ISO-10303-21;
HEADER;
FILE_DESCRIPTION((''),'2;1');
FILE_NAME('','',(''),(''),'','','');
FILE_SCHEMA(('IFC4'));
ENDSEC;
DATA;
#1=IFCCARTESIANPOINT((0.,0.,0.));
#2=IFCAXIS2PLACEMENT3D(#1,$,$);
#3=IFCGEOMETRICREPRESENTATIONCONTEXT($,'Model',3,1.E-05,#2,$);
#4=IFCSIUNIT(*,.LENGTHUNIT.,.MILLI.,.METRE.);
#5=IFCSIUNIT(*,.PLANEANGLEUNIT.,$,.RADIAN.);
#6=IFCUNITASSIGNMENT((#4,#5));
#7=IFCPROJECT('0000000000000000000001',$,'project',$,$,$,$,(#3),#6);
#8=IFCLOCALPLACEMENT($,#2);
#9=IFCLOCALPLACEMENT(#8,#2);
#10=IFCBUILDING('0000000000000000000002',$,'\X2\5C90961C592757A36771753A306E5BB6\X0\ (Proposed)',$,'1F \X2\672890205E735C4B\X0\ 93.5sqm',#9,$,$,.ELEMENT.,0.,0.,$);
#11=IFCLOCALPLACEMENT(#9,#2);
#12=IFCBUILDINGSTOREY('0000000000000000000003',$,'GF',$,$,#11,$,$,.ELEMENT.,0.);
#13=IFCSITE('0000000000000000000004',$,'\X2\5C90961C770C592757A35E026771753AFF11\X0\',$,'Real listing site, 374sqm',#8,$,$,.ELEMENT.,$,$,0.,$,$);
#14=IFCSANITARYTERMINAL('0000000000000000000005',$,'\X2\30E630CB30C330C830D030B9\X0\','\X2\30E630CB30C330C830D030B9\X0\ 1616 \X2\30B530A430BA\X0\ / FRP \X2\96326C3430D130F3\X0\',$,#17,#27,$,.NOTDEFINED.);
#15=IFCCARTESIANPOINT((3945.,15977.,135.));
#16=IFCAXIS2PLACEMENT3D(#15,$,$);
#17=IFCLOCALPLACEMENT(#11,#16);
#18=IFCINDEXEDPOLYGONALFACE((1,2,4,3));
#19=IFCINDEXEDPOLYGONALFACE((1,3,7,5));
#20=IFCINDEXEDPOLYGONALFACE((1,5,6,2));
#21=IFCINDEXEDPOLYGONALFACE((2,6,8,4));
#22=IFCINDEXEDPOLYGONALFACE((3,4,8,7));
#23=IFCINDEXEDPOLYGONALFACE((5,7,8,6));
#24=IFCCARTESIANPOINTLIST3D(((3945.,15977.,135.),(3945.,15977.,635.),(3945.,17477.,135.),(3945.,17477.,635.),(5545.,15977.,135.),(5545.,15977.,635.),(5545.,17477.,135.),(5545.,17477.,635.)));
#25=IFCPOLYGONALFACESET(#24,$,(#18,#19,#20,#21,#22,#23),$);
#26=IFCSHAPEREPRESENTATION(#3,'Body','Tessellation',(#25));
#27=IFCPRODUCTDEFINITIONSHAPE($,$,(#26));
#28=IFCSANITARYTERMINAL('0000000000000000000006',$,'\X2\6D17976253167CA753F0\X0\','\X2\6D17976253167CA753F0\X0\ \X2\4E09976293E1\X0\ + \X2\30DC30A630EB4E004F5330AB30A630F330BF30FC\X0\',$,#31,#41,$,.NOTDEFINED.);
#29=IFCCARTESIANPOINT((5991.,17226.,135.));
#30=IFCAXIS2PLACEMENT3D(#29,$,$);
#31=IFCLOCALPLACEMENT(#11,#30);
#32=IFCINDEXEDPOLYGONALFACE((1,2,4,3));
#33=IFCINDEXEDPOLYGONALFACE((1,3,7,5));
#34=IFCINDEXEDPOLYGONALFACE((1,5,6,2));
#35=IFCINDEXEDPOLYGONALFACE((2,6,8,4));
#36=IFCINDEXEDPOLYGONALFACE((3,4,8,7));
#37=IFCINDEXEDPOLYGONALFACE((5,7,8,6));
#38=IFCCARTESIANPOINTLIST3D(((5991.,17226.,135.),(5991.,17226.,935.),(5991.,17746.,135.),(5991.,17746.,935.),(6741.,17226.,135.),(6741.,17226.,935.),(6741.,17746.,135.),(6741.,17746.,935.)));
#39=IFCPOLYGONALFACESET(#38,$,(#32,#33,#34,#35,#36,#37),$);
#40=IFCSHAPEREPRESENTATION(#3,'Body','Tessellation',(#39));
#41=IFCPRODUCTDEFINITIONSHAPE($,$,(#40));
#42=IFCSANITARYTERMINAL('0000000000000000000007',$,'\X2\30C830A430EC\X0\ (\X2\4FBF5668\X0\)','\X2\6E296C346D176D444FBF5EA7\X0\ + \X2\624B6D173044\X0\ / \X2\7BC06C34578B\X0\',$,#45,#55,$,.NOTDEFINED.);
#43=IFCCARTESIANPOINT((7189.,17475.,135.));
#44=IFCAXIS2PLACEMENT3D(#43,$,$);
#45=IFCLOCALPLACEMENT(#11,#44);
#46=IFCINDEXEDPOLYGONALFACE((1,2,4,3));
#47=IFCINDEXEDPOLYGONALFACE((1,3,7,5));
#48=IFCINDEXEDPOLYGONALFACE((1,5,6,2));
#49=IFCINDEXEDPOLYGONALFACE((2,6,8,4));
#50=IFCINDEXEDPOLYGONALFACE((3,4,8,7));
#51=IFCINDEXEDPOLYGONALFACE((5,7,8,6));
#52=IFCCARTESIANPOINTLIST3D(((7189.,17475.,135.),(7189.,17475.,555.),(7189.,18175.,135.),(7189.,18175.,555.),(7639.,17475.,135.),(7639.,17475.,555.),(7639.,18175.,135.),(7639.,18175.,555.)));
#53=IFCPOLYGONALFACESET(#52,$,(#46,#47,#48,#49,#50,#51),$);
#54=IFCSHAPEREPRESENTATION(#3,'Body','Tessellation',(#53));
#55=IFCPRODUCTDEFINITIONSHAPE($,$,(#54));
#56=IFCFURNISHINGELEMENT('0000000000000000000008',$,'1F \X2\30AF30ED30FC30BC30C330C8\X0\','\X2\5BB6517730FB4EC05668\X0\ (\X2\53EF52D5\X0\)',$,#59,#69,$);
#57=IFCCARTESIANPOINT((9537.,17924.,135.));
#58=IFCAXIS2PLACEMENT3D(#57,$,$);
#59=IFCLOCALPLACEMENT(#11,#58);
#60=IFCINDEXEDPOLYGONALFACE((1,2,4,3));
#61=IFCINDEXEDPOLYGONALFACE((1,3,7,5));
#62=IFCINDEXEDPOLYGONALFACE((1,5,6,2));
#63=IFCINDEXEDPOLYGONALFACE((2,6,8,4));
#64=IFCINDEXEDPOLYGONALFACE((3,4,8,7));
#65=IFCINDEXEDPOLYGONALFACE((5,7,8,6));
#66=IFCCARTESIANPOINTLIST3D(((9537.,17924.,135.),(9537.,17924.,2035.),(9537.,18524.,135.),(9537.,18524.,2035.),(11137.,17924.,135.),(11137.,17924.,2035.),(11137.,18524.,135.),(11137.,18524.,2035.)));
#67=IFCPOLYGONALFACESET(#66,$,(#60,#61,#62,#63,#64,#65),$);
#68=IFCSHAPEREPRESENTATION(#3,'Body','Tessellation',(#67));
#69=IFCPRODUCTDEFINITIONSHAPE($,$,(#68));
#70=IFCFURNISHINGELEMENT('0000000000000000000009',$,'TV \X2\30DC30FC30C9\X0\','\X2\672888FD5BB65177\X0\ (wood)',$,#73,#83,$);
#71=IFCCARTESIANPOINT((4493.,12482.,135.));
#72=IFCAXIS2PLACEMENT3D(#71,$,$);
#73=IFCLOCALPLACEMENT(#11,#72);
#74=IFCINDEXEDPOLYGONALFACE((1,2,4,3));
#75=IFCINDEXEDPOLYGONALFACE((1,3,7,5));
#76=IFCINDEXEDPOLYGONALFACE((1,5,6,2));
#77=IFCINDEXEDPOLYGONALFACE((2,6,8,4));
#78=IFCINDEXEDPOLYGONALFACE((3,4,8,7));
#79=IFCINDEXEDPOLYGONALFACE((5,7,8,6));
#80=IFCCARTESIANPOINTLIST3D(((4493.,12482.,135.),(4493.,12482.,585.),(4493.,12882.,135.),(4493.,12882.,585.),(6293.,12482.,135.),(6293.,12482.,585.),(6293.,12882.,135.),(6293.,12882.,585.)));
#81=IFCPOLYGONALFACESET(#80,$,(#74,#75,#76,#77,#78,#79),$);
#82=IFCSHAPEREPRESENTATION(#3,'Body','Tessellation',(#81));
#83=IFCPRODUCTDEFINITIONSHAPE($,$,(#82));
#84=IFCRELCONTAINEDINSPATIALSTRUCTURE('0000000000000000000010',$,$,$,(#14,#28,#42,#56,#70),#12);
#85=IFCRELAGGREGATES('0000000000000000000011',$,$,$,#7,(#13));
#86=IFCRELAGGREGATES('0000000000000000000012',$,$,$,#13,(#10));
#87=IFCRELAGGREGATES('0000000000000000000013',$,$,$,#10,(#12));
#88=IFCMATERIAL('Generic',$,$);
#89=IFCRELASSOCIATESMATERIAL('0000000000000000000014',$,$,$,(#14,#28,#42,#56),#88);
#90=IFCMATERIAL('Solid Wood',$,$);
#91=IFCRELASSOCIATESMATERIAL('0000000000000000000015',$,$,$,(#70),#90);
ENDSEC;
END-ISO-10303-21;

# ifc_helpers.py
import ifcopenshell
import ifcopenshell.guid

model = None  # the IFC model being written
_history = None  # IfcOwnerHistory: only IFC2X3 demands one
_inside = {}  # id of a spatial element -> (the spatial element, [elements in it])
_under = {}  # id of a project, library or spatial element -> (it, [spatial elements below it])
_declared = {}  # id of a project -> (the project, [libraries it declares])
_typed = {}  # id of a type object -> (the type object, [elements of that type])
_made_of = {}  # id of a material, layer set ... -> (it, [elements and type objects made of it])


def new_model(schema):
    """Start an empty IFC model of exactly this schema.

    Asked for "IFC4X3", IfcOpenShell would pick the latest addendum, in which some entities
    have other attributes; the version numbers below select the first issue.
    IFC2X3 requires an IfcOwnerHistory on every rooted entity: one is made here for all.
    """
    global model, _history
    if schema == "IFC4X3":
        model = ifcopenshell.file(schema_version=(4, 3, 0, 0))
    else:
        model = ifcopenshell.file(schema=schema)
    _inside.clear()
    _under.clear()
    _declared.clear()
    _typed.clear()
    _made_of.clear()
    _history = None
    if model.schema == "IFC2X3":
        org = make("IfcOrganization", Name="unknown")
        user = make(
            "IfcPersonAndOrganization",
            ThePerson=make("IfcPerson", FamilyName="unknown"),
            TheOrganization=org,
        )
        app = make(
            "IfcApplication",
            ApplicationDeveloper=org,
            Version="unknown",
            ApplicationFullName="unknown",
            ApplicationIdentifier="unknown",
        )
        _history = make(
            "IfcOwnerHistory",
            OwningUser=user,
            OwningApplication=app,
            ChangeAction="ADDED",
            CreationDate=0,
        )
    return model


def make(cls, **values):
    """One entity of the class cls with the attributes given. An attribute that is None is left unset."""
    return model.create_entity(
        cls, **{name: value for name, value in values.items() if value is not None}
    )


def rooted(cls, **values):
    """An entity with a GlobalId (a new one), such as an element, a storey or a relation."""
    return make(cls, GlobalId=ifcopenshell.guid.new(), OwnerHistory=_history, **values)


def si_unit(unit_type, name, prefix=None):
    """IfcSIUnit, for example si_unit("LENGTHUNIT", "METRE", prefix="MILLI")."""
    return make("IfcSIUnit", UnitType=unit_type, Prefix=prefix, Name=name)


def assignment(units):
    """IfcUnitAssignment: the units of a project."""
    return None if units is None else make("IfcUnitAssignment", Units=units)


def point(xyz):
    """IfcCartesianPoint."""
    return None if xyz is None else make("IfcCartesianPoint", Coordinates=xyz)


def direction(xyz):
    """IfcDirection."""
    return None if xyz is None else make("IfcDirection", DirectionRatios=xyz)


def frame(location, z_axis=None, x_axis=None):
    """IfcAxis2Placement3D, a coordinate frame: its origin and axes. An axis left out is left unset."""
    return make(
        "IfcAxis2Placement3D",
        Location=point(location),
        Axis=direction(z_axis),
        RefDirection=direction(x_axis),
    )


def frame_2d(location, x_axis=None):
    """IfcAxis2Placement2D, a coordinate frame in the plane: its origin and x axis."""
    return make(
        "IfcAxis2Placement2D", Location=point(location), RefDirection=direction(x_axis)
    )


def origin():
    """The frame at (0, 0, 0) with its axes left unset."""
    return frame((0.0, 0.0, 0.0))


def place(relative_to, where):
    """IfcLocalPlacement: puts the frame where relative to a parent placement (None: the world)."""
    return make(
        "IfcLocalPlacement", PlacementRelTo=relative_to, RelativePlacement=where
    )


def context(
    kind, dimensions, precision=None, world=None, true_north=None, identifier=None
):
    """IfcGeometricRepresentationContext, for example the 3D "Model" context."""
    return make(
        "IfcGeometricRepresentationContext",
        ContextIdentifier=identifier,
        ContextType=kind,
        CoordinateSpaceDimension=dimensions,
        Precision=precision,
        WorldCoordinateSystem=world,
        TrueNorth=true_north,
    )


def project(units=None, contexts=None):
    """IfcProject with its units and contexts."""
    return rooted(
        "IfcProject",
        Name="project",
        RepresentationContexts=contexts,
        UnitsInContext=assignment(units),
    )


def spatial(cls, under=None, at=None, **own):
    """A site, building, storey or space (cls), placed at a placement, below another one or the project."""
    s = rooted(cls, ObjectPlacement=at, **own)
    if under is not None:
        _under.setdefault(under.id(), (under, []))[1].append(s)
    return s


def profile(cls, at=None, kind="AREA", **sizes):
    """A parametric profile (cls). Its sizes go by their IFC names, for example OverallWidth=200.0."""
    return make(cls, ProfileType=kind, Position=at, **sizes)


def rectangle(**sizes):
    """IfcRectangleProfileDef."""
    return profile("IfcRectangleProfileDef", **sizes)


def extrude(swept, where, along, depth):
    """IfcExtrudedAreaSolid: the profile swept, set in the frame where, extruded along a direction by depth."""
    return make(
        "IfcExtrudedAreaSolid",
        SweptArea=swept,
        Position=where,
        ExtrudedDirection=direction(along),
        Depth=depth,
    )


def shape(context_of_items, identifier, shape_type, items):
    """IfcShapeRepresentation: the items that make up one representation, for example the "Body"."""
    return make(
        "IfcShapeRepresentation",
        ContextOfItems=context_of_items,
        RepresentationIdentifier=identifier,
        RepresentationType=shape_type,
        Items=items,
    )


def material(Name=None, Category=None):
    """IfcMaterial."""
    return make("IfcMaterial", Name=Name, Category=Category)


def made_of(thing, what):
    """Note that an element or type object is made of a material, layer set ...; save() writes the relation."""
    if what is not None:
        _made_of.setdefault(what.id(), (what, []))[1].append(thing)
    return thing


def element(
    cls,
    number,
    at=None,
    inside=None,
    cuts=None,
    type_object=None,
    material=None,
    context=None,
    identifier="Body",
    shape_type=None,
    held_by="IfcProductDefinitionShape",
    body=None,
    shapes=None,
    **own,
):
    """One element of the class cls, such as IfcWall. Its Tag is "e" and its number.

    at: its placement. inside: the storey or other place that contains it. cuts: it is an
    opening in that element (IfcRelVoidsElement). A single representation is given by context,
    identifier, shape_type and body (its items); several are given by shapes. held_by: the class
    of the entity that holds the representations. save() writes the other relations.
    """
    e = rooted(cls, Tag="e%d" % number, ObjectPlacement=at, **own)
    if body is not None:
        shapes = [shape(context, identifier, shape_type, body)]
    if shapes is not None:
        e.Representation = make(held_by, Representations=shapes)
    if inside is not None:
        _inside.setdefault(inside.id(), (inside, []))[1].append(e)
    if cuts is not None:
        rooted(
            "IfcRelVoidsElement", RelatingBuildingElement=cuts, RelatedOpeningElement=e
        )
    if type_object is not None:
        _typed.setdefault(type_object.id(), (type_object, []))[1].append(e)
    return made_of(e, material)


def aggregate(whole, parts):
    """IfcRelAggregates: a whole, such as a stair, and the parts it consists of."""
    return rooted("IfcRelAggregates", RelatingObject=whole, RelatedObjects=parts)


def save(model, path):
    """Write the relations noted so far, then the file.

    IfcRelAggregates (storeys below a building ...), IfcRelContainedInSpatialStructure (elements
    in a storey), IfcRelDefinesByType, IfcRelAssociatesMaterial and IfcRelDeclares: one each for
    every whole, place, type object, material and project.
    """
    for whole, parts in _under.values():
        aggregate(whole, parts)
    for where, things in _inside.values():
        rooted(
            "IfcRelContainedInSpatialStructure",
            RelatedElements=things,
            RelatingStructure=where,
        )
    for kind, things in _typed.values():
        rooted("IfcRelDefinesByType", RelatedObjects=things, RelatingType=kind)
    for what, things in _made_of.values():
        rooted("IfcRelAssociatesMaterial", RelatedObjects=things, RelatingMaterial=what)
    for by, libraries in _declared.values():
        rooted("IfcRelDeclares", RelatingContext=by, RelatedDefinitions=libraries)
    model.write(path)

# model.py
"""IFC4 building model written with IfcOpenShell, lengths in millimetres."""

from ifc_helpers import new_model, si_unit, frame, frame_2d, origin, place, context, project, spatial, rectangle, extrude, material, element, save


model = new_model("IFC4")

# Units and contexts
model_context = context("Model", 3, precision=1e-05, world=origin())
ifc_project = project(units=[si_unit("LENGTHUNIT", "METRE", prefix="MILLI"), si_unit("PLANEANGLEUNIT", "RADIAN")], contexts=[model_context])

# Site, building, storey
site_placement = place(None, origin())
site = spatial("IfcSite", under=ifc_project, at=site_placement, Name="岐阜県大垣市東町１", ObjectType="Real listing site, 374sqm", CompositionType="ELEMENT", RefElevation=0.0)
building_placement = place(site_placement, origin())
building = spatial("IfcBuilding", under=site, at=building_placement, Name="岐阜大垣東町の家 (Proposed)", ObjectType="1F 木造平屋 93.5sqm", CompositionType="ELEMENT", ElevationOfRefHeight=0.0, ElevationOfTerrain=0.0)
storey_placement = place(building_placement, origin())
storey = spatial("IfcBuildingStorey", under=building, at=storey_placement, Name="GF", CompositionType="ELEMENT", Elevation=0.0)

# Shared definitions
ifc_material_1 = material(Name="Solid Wood")

# Sanitary terminals
ifc_material_2 = material(Name="Generic")
sanitary_terminal_1_placement = place(storey_placement, frame((3945.0, 15977.0, 135.0)))
element("IfcSanitaryTerminal", 1, at=sanitary_terminal_1_placement, inside=storey, material=ifc_material_2, Name="ユニットバス", Description="ユニットバス 1616 サイズ / FRP 防水パン", PredefinedType="NOTDEFINED", context=model_context, shape_type="SweptSolid", body=[
    extrude(rectangle(XDim=1600.0, YDim=1500.0, at=frame_2d((800.0, 750.0))), frame((3945.0, 15977.0, 135.0)), (0.0, 0.0, 1.0), 500.0),
])
sanitary_terminal_2_placement = place(storey_placement, frame((5991.0, 17226.0, 135.0)))
element("IfcSanitaryTerminal", 2, at=sanitary_terminal_2_placement, inside=storey, material=ifc_material_2, Name="洗面化粧台", Description="洗面化粧台 三面鏡 + ボウル一体カウンター", PredefinedType="NOTDEFINED", context=model_context, shape_type="SweptSolid", body=[
    extrude(rectangle(XDim=750.0, YDim=520.0, at=frame_2d((375.0, 260.0))), frame((5991.0, 17226.0, 135.0)), (0.0, 0.0, 1.0), 800.0),
])
sanitary_terminal_3_placement = place(storey_placement, frame((7189.0, 17475.0, 135.0)))
element("IfcSanitaryTerminal", 3, at=sanitary_terminal_3_placement, inside=storey, material=ifc_material_2, Name="トイレ (便器)", Description="温水洗浄便座 + 手洗い / 節水型", PredefinedType="NOTDEFINED", context=model_context, shape_type="SweptSolid", body=[
    extrude(rectangle(XDim=450.0, YDim=700.0, at=frame_2d((225.0, 350.0))), frame((7189.0, 17475.0, 135.0)), (0.0, 0.0, 1.0), 420.0),
])

# Furnishing elements
furnishing_1_placement = place(storey_placement, frame((9537.0, 17924.0, 135.0)))
element("IfcFurnishingElement", 4, at=furnishing_1_placement, inside=storey, material=ifc_material_2, Name="1F クローゼット", Description="家具・什器 (可動)", context=model_context, shape_type="SweptSolid", body=[
    extrude(rectangle(XDim=1600.0, YDim=600.0, at=frame_2d((800.0, 300.0))), frame((9537.0, 17924.0, 135.0)), (0.0, 0.0, 1.0), 1900.0),
])
furnishing_2_placement = place(storey_placement, frame((4493.0, 12482.0, 135.0)))
element("IfcFurnishingElement", 5, at=furnishing_2_placement, inside=storey, material=ifc_material_1, Name="TV ボード", Description="木製家具 (wood)", context=model_context, shape_type="SweptSolid", body=[
    extrude(rectangle(XDim=1800.0, YDim=400.0, at=frame_2d((900.0, 200.0))), frame((4493.0, 12482.0, 135.0)), (0.0, 0.0, 1.0), 450.0),
])

save(model, "model.ifc")
